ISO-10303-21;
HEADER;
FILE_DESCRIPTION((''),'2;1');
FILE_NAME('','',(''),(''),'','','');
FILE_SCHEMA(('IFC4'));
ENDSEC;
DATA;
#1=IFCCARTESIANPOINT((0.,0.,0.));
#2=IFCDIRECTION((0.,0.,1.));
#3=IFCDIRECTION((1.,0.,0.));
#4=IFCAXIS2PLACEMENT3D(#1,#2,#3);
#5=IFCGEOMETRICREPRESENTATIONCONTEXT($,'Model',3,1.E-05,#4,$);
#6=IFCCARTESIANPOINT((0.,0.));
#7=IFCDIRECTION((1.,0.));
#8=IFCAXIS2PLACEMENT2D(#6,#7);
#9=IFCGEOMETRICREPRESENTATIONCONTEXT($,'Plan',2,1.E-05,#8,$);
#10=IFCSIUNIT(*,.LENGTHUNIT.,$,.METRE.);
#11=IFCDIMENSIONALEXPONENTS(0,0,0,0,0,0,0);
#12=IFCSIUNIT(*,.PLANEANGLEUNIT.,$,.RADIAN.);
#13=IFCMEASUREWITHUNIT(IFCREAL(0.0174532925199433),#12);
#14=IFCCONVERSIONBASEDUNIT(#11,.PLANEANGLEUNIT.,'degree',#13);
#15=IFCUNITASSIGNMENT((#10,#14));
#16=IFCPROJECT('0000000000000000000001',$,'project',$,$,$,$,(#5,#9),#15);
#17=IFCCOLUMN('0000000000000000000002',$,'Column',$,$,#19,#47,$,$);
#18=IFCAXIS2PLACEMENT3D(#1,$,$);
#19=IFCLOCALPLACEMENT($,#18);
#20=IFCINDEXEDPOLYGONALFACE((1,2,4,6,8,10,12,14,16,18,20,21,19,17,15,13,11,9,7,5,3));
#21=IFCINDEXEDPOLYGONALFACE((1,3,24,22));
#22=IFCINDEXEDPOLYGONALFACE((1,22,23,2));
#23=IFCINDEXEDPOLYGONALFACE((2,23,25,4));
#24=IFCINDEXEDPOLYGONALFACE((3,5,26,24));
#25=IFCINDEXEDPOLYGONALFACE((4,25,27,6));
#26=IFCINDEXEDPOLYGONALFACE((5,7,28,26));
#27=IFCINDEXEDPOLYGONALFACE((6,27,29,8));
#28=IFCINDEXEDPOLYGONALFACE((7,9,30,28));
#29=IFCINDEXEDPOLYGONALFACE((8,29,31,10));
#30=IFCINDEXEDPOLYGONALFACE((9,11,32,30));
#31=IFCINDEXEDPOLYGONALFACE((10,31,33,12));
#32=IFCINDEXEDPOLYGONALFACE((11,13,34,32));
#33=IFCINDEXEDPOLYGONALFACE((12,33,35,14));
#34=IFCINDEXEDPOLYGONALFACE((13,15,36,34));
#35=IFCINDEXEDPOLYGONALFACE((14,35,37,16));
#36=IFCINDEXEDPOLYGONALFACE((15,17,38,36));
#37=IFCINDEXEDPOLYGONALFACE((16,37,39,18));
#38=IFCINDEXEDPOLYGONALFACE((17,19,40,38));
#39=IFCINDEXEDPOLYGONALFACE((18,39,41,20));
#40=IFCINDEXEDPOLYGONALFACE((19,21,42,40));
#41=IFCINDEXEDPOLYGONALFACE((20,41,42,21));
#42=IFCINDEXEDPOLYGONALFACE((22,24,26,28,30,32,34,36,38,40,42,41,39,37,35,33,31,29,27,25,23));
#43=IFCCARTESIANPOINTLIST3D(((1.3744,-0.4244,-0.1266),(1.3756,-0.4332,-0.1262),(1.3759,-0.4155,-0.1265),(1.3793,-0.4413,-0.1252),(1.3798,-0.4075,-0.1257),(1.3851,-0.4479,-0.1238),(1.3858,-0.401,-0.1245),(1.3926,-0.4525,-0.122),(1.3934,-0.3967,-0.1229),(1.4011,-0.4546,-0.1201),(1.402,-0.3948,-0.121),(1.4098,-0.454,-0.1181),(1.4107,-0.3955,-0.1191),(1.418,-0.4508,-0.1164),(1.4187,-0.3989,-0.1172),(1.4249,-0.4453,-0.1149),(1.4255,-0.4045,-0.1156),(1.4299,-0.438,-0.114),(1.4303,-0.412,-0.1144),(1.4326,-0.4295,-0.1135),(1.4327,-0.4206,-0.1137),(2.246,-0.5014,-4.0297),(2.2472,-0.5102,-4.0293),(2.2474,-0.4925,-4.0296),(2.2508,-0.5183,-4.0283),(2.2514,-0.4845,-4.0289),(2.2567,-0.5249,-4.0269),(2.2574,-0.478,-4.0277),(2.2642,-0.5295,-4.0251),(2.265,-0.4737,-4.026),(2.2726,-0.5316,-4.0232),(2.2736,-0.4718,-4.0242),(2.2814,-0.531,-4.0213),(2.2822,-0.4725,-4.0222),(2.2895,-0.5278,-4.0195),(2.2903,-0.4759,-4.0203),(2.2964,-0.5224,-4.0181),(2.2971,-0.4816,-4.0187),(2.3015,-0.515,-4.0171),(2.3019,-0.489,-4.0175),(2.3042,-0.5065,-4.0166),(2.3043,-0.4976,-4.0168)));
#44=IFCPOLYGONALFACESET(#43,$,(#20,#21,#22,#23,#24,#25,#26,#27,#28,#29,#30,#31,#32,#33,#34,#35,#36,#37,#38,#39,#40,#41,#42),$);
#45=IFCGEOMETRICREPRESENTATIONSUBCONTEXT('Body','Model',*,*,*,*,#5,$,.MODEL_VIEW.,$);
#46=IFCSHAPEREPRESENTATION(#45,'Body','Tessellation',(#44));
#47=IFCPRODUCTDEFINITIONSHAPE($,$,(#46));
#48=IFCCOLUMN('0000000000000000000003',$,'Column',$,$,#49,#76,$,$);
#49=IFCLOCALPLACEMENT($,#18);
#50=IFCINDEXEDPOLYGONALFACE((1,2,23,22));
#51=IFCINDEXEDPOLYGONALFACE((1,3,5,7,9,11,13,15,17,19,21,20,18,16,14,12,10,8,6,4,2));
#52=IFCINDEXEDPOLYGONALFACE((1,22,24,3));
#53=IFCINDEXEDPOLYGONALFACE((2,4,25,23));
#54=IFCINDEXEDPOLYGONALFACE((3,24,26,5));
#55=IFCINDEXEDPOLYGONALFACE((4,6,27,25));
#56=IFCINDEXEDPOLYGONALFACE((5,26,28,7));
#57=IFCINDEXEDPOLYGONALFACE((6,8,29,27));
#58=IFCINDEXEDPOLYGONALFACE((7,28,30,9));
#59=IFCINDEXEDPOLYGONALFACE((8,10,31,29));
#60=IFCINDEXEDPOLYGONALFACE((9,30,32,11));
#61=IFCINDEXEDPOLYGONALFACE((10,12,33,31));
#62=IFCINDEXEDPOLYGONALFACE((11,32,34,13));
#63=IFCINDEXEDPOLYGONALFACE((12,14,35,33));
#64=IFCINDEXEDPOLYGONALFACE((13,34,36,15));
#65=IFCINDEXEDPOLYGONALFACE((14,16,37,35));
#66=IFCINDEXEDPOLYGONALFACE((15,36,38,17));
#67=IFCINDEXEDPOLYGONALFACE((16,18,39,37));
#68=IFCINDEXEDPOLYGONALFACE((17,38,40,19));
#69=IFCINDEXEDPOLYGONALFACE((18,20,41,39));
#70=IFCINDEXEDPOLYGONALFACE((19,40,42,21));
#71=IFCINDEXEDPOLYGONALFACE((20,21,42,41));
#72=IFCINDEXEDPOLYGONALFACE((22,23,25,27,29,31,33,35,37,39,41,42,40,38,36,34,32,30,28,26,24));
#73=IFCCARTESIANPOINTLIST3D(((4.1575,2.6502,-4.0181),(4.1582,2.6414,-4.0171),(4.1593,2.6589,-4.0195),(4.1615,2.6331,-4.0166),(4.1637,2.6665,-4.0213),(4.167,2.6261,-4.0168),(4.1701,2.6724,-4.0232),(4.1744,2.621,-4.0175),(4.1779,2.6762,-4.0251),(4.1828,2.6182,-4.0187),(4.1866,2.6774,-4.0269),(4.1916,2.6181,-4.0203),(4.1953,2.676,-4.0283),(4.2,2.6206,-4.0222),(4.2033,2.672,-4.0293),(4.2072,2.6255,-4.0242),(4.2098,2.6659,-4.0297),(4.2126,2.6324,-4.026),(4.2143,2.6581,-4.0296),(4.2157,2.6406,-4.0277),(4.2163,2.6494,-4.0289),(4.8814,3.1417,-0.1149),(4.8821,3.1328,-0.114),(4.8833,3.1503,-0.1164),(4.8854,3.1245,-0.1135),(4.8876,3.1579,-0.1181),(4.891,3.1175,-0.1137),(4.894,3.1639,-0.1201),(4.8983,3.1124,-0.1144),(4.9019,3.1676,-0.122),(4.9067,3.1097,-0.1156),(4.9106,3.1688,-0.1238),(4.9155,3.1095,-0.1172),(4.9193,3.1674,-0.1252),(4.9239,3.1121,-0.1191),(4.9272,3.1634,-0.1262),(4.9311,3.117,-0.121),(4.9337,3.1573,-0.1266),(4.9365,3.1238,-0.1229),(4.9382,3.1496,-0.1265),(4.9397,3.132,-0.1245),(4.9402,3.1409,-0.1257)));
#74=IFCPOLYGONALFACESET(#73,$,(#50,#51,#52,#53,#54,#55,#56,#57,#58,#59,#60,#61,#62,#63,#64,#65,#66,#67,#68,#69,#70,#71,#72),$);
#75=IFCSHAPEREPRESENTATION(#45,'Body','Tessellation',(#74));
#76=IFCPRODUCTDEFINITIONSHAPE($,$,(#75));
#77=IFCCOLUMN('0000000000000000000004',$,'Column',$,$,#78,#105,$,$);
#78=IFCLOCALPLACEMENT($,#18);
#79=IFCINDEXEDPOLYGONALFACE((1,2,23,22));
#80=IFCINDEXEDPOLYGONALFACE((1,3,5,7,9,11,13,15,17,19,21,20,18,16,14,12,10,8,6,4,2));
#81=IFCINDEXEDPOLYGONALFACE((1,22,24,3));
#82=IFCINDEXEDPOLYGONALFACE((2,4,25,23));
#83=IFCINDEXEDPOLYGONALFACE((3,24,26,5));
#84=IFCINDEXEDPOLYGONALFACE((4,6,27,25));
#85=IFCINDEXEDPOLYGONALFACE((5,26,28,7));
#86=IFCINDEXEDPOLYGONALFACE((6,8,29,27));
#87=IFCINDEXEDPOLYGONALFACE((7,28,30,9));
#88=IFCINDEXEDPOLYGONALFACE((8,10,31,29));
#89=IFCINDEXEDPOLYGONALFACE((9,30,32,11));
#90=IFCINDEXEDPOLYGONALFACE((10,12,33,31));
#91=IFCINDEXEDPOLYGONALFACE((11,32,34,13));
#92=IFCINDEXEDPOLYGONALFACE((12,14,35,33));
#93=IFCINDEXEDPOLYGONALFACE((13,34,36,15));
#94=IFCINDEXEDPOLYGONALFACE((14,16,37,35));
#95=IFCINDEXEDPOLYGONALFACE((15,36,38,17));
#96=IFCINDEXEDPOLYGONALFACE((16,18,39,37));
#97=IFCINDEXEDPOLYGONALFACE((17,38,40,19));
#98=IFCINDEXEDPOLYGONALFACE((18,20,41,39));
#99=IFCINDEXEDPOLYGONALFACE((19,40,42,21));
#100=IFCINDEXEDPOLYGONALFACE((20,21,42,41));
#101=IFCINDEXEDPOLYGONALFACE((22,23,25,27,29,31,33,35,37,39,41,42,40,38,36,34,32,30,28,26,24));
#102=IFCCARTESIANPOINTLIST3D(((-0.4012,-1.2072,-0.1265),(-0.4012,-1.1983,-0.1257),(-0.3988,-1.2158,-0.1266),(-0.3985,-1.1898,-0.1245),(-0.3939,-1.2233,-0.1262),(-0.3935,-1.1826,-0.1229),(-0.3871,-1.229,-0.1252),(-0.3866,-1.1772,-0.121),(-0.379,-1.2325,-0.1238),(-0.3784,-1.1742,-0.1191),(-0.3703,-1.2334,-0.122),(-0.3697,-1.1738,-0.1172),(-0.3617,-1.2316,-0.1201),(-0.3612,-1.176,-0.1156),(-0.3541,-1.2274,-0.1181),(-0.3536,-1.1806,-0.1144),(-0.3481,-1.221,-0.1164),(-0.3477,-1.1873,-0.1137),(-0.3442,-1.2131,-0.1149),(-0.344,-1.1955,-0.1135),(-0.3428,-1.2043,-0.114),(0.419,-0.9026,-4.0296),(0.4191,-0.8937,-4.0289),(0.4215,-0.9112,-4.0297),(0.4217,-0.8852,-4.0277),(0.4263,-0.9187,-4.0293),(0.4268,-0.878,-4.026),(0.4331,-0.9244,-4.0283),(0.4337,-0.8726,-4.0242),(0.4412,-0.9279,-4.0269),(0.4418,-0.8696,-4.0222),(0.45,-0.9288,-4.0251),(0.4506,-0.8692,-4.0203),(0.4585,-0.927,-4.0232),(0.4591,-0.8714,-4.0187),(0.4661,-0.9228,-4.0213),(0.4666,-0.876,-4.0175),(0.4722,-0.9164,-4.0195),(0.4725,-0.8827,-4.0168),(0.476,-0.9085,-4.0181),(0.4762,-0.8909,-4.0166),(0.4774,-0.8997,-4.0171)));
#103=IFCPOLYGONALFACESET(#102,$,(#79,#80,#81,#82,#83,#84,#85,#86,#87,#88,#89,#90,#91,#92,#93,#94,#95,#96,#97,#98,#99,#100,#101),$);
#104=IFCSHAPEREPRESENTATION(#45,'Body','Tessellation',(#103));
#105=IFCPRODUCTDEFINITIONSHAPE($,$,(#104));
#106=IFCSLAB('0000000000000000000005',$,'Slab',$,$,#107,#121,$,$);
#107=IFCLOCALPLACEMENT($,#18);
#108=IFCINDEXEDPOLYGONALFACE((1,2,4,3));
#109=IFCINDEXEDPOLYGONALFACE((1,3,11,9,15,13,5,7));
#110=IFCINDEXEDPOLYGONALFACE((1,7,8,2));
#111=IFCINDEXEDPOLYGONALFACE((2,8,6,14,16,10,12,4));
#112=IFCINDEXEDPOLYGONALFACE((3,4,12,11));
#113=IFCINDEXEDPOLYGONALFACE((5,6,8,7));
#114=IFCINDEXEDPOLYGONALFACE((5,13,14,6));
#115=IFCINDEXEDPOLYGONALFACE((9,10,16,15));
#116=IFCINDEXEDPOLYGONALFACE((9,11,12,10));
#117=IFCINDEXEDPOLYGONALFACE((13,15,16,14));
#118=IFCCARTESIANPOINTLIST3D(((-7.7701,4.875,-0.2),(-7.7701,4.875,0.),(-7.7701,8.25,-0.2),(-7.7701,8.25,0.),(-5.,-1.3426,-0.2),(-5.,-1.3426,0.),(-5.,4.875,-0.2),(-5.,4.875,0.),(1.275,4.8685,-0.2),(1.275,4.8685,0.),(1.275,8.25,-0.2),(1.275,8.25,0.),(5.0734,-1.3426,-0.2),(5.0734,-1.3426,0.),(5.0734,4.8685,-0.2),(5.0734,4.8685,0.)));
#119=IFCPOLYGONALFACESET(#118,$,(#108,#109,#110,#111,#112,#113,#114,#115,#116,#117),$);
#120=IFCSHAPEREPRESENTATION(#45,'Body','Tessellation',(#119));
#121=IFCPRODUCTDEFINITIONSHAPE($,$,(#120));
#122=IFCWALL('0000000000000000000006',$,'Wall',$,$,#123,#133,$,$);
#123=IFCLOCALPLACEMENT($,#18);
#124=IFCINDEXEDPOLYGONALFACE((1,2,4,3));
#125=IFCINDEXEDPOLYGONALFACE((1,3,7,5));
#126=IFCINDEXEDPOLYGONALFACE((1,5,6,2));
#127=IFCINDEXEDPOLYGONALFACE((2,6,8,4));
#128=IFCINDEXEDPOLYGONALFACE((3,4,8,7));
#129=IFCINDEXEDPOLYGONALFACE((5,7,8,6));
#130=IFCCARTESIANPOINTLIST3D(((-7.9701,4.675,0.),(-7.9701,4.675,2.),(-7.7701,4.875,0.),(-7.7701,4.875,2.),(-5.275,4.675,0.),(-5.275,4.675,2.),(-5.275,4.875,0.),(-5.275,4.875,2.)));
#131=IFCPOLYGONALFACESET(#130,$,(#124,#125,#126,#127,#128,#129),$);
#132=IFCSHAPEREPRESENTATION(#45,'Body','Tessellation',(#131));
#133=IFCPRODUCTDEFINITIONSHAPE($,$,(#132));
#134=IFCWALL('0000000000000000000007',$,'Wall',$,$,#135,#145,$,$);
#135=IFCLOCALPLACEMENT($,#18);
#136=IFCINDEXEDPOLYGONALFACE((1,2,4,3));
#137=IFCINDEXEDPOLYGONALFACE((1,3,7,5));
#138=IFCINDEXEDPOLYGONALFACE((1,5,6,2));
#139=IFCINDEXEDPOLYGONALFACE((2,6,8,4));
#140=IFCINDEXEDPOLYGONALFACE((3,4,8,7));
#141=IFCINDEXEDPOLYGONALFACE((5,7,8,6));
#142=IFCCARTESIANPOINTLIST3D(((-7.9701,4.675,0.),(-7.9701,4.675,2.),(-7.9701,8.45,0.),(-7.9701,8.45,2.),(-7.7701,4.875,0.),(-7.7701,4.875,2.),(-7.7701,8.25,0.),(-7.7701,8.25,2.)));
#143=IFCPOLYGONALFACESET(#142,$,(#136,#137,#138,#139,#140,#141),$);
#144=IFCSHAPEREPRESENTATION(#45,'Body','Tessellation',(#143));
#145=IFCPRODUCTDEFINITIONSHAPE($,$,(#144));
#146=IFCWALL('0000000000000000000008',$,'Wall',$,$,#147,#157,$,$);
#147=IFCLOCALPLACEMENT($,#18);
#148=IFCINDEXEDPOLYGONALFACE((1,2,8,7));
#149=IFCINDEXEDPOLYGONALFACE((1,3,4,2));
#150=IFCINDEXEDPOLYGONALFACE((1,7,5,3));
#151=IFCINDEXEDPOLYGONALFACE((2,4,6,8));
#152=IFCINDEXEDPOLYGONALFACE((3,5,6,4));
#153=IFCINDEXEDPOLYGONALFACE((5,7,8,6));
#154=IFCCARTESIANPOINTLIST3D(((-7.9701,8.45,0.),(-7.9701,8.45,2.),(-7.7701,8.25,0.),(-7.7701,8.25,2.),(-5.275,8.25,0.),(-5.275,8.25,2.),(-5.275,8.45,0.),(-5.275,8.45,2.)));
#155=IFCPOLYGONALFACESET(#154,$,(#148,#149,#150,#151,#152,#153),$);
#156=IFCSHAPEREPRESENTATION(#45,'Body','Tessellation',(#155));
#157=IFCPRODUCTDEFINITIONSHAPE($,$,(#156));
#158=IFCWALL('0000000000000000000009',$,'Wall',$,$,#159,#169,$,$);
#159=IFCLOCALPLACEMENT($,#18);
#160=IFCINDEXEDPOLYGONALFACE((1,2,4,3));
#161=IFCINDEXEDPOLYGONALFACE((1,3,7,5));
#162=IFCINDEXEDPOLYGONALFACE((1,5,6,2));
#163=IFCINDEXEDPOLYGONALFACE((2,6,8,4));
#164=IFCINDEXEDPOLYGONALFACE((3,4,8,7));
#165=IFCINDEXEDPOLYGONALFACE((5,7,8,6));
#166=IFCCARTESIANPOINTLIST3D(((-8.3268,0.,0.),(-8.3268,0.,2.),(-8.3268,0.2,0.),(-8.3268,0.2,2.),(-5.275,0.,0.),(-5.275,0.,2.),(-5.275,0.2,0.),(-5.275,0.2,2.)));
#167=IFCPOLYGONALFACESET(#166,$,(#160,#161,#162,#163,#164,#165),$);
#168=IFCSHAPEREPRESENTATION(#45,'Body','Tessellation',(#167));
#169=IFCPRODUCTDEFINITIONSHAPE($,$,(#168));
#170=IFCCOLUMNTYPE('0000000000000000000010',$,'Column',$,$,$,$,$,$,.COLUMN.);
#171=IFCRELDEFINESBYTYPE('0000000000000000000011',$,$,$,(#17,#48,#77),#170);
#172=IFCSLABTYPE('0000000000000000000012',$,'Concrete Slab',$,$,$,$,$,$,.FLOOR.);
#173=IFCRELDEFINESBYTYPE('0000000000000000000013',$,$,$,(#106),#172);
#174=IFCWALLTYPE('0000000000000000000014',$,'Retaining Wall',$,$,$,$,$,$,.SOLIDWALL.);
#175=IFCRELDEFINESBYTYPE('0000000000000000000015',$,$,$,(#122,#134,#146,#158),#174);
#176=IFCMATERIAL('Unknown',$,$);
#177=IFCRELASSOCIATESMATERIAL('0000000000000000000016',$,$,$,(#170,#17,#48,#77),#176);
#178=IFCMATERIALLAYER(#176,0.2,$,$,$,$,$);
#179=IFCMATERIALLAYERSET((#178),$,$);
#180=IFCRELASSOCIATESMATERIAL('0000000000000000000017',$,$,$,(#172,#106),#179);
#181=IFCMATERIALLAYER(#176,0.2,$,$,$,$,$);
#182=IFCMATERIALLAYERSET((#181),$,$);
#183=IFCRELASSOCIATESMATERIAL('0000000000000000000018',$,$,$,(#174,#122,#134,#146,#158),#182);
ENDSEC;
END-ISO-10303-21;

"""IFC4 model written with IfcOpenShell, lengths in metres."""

from ifc_helpers import new_model, entity, si_unit, converted_unit, frame, origin_with_axes, origin_2d_with_axis, place, context, subcontext, project, line, indexed_curve, circle, outline, extrude, clip, halfspace, material, layer, layer_set, layer_usage, material_profile, profile_set, profile_usage, type_object, element, save


model = new_model("IFC4")

# Units and contexts
model_context = context("Model", 3, precision=1e-05, world=origin_with_axes())
plan_context = context("Plan", 2, precision=1e-05, world=origin_2d_with_axis())
body_context = subcontext(model_context, "Body", "Model", "MODEL_VIEW")
ifc_project = project(units=[si_unit("LENGTHUNIT", "METRE"), converted_unit("PLANEANGLEUNIT", "degree", entity("IfcReal", 0.0174532925199433), si_unit("PLANEANGLEUNIT", "RADIAN"), dimensions=[0, 0, 0, 0, 0, 0, 0])], contexts=[model_context, plan_context])

# Columns
ifc_material = material(Name="Unknown")
ifc_material_profile = material_profile(ifc_material, circle(Radius=0.03))
ifc_profile_set = profile_set([ifc_material_profile])
column_type = type_object("IfcColumnType", Name="Column", PredefinedType="COLUMN", material=ifc_profile_set)
ifc_profile_usage_1 = profile_usage(ifc_profile_set, cardinal=5)
column_1_placement = place(None, frame((2.2753, -0.5017, -4.0232), z_axis=(-0.217892, 0.019251, 0.975783), x_axis=(-0.088007, -0.99612, 0.0)))
element("IfcColumn", 1, at=column_1_placement, type_object=column_type, material=ifc_profile_usage_1, Name="Column", context=body_context, shape_type="SweptSolid", body=[
    extrude(circle(Radius=0.03), origin_with_axes(), (0.0, 0.0, 1.0), 4.0),
])
ifc_profile_usage_2 = profile_usage(ifc_profile_set, cardinal=5)
column_2_placement = place(None, frame((4.1869, 2.6476, -4.0232), z_axis=(0.18098, 0.122856, 0.975783), x_axis=(-0.561651, 0.827374, 0.0)))
element("IfcColumn", 2, at=column_2_placement, type_object=column_type, material=ifc_profile_usage_2, Name="Column", context=body_context, shape_type="SweptSolid", body=[
    extrude(circle(Radius=0.03), origin_with_axes(), (0.0, 0.0, 1.0), 4.0),
])
ifc_profile_usage_3 = profile_usage(ifc_profile_set, cardinal=5)
column_3_placement = place(None, frame((0.4481, -0.8989, -4.0232), z_axis=(-0.205058, -0.076149, 0.975783), x_axis=(0.348124, -0.937448, 0.0)))
element("IfcColumn", 3, at=column_3_placement, type_object=column_type, material=ifc_profile_usage_3, Name="Column", context=body_context, shape_type="SweptSolid", body=[
    extrude(circle(Radius=0.03), origin_with_axes(), (0.0, 0.0, 1.0), 4.0),
])

# Slab
ifc_layer_1 = layer(ifc_material, 0.2)
ifc_layer_set_1 = layer_set([ifc_layer_1])
ifc_layer_usage_1 = layer_usage(ifc_layer_set_1, "AXIS3", "POSITIVE", 0.0)
slab_type = type_object("IfcSlabType", Name="Concrete Slab", PredefinedType="FLOOR", material=ifc_layer_set_1)
slab_placement = place(None, frame((1.275, 0.0, -0.2), z_axis=(0.0, 0.0, 1.0), x_axis=(1.0, 0.0, 0.0)))
element("IfcSlab", 4, at=slab_placement, type_object=slab_type, material=ifc_layer_usage_1, Name="Slab", context=body_context, shape_type="SweptSolid", body=[
    extrude(outline(indexed_curve([(0.0, 8.25), (-9.0451, 8.25), (-9.0451, 4.875), (-6.275, 4.875), (-6.275, -1.3426), (3.7984, -1.3426), (3.7984, 4.8685), (0.0, 4.8685)], segments=[line(5, 6), line(6, 7), line(7, 8), line(8, 1), line(1, 2), line(2, 3), line(3, 4), line(4, 5)], self_intersect=False)), None, (0.0, 0.0, 1.0), 0.2),
])

# Walls
ifc_layer_2 = layer(ifc_material, 0.2)
ifc_layer_set_2 = layer_set([ifc_layer_2])
ifc_layer_usage_2 = layer_usage(ifc_layer_set_2, "AXIS2", "POSITIVE", 0.0)
wall_type = type_object("IfcWallType", Name="Retaining Wall", PredefinedType="SOLIDWALL", material=ifc_layer_set_2)
wall_1_placement = place(None, frame((-7.9701, 4.675, 0.0), z_axis=(0.0, 0.0, 1.0), x_axis=(1.0, 0.0, 0.0)))
element("IfcWall", 5, at=wall_1_placement, type_object=wall_type, material=ifc_layer_usage_2, Name="Wall", context=body_context, shape_type="Clipping", body=[
    clip(extrude(outline(indexed_curve([(0.0, 0.0), (0.0, 0.2), (2.6951, 0.2), (2.6951, 0.0), (0.0, 0.0)], self_intersect=False)), origin_with_axes(), (0.0, 0.0, 1.0), 2.0), halfspace(frame((0.0, 0.0, 0.0), z_axis=(-0.707108, 0.707106, 0.0), x_axis=(0.707106, 0.707108, 0.0)), False)),
])
ifc_layer_usage_3 = layer_usage(ifc_layer_set_2, "AXIS2", "POSITIVE", 0.0)
wall_2_placement = place(None, frame((-7.9701, 8.45, 0.0), z_axis=(0.0, 0.0, 1.0), x_axis=(0.0, -1.0, 0.0)))
element("IfcWall", 6, at=wall_2_placement, type_object=wall_type, material=ifc_layer_usage_3, Name="Wall", context=body_context, shape_type="Clipping", body=[
    clip(clip(extrude(outline(indexed_curve([(0.0, 0.0), (0.0, 0.2), (3.775, 0.2), (3.775, 0.0), (0.0, 0.0)], self_intersect=False)), origin_with_axes(), (0.0, 0.0, 1.0), 2.0), halfspace(frame((0.0, 0.0, 0.0), z_axis=(-0.707106, 0.707107, 0.0), x_axis=(0.707107, 0.707107, 0.0)), False)), halfspace(frame((3.775, 0.0, 0.0), z_axis=(0.707106, 0.707107, 0.0), x_axis=(0.707107, -0.707106, 0.0)), False)),
])
ifc_layer_usage_4 = layer_usage(ifc_layer_set_2, "AXIS2", "POSITIVE", 0.0)
wall_3_placement = place(None, frame((-5.275, 8.45, 0.0), z_axis=(0.0, 0.0, 1.0), x_axis=(-1.0, 0.0, 0.0)))
element("IfcWall", 7, at=wall_3_placement, type_object=wall_type, material=ifc_layer_usage_4, Name="Wall", context=body_context, shape_type="Clipping", body=[
    clip(extrude(outline(indexed_curve([(0.0, 0.0), (0.0, 0.2), (2.6951, 0.2), (2.6951, 0.0), (0.0, 0.0)], self_intersect=False)), origin_with_axes(), (0.0, 0.0, 1.0), 2.0), halfspace(frame((2.6951, 0.0, 0.0), z_axis=(0.707107, 0.707106, 0.0), x_axis=(0.707106, -0.707107, 0.0)), False)),
])
ifc_layer_usage_5 = layer_usage(ifc_layer_set_2, "AXIS2", "POSITIVE", 0.0)
wall_4_placement = place(None, frame((-8.3268, 0.0, 0.0), z_axis=(0.0, 0.0, 1.0), x_axis=(1.0, 0.0, 0.0)))
element("IfcWall", 8, at=wall_4_placement, type_object=wall_type, material=ifc_layer_usage_5, Name="Wall", context=body_context, shape_type="SweptSolid", body=[
    extrude(outline(indexed_curve([(0.0, 0.0), (0.0, 0.2), (3.0518, 0.2), (3.0518, 0.0), (0.0, 0.0)], self_intersect=False)), origin_with_axes(), (0.0, 0.0, 1.0), 2.0),
])

save(model, "model.ifc")
